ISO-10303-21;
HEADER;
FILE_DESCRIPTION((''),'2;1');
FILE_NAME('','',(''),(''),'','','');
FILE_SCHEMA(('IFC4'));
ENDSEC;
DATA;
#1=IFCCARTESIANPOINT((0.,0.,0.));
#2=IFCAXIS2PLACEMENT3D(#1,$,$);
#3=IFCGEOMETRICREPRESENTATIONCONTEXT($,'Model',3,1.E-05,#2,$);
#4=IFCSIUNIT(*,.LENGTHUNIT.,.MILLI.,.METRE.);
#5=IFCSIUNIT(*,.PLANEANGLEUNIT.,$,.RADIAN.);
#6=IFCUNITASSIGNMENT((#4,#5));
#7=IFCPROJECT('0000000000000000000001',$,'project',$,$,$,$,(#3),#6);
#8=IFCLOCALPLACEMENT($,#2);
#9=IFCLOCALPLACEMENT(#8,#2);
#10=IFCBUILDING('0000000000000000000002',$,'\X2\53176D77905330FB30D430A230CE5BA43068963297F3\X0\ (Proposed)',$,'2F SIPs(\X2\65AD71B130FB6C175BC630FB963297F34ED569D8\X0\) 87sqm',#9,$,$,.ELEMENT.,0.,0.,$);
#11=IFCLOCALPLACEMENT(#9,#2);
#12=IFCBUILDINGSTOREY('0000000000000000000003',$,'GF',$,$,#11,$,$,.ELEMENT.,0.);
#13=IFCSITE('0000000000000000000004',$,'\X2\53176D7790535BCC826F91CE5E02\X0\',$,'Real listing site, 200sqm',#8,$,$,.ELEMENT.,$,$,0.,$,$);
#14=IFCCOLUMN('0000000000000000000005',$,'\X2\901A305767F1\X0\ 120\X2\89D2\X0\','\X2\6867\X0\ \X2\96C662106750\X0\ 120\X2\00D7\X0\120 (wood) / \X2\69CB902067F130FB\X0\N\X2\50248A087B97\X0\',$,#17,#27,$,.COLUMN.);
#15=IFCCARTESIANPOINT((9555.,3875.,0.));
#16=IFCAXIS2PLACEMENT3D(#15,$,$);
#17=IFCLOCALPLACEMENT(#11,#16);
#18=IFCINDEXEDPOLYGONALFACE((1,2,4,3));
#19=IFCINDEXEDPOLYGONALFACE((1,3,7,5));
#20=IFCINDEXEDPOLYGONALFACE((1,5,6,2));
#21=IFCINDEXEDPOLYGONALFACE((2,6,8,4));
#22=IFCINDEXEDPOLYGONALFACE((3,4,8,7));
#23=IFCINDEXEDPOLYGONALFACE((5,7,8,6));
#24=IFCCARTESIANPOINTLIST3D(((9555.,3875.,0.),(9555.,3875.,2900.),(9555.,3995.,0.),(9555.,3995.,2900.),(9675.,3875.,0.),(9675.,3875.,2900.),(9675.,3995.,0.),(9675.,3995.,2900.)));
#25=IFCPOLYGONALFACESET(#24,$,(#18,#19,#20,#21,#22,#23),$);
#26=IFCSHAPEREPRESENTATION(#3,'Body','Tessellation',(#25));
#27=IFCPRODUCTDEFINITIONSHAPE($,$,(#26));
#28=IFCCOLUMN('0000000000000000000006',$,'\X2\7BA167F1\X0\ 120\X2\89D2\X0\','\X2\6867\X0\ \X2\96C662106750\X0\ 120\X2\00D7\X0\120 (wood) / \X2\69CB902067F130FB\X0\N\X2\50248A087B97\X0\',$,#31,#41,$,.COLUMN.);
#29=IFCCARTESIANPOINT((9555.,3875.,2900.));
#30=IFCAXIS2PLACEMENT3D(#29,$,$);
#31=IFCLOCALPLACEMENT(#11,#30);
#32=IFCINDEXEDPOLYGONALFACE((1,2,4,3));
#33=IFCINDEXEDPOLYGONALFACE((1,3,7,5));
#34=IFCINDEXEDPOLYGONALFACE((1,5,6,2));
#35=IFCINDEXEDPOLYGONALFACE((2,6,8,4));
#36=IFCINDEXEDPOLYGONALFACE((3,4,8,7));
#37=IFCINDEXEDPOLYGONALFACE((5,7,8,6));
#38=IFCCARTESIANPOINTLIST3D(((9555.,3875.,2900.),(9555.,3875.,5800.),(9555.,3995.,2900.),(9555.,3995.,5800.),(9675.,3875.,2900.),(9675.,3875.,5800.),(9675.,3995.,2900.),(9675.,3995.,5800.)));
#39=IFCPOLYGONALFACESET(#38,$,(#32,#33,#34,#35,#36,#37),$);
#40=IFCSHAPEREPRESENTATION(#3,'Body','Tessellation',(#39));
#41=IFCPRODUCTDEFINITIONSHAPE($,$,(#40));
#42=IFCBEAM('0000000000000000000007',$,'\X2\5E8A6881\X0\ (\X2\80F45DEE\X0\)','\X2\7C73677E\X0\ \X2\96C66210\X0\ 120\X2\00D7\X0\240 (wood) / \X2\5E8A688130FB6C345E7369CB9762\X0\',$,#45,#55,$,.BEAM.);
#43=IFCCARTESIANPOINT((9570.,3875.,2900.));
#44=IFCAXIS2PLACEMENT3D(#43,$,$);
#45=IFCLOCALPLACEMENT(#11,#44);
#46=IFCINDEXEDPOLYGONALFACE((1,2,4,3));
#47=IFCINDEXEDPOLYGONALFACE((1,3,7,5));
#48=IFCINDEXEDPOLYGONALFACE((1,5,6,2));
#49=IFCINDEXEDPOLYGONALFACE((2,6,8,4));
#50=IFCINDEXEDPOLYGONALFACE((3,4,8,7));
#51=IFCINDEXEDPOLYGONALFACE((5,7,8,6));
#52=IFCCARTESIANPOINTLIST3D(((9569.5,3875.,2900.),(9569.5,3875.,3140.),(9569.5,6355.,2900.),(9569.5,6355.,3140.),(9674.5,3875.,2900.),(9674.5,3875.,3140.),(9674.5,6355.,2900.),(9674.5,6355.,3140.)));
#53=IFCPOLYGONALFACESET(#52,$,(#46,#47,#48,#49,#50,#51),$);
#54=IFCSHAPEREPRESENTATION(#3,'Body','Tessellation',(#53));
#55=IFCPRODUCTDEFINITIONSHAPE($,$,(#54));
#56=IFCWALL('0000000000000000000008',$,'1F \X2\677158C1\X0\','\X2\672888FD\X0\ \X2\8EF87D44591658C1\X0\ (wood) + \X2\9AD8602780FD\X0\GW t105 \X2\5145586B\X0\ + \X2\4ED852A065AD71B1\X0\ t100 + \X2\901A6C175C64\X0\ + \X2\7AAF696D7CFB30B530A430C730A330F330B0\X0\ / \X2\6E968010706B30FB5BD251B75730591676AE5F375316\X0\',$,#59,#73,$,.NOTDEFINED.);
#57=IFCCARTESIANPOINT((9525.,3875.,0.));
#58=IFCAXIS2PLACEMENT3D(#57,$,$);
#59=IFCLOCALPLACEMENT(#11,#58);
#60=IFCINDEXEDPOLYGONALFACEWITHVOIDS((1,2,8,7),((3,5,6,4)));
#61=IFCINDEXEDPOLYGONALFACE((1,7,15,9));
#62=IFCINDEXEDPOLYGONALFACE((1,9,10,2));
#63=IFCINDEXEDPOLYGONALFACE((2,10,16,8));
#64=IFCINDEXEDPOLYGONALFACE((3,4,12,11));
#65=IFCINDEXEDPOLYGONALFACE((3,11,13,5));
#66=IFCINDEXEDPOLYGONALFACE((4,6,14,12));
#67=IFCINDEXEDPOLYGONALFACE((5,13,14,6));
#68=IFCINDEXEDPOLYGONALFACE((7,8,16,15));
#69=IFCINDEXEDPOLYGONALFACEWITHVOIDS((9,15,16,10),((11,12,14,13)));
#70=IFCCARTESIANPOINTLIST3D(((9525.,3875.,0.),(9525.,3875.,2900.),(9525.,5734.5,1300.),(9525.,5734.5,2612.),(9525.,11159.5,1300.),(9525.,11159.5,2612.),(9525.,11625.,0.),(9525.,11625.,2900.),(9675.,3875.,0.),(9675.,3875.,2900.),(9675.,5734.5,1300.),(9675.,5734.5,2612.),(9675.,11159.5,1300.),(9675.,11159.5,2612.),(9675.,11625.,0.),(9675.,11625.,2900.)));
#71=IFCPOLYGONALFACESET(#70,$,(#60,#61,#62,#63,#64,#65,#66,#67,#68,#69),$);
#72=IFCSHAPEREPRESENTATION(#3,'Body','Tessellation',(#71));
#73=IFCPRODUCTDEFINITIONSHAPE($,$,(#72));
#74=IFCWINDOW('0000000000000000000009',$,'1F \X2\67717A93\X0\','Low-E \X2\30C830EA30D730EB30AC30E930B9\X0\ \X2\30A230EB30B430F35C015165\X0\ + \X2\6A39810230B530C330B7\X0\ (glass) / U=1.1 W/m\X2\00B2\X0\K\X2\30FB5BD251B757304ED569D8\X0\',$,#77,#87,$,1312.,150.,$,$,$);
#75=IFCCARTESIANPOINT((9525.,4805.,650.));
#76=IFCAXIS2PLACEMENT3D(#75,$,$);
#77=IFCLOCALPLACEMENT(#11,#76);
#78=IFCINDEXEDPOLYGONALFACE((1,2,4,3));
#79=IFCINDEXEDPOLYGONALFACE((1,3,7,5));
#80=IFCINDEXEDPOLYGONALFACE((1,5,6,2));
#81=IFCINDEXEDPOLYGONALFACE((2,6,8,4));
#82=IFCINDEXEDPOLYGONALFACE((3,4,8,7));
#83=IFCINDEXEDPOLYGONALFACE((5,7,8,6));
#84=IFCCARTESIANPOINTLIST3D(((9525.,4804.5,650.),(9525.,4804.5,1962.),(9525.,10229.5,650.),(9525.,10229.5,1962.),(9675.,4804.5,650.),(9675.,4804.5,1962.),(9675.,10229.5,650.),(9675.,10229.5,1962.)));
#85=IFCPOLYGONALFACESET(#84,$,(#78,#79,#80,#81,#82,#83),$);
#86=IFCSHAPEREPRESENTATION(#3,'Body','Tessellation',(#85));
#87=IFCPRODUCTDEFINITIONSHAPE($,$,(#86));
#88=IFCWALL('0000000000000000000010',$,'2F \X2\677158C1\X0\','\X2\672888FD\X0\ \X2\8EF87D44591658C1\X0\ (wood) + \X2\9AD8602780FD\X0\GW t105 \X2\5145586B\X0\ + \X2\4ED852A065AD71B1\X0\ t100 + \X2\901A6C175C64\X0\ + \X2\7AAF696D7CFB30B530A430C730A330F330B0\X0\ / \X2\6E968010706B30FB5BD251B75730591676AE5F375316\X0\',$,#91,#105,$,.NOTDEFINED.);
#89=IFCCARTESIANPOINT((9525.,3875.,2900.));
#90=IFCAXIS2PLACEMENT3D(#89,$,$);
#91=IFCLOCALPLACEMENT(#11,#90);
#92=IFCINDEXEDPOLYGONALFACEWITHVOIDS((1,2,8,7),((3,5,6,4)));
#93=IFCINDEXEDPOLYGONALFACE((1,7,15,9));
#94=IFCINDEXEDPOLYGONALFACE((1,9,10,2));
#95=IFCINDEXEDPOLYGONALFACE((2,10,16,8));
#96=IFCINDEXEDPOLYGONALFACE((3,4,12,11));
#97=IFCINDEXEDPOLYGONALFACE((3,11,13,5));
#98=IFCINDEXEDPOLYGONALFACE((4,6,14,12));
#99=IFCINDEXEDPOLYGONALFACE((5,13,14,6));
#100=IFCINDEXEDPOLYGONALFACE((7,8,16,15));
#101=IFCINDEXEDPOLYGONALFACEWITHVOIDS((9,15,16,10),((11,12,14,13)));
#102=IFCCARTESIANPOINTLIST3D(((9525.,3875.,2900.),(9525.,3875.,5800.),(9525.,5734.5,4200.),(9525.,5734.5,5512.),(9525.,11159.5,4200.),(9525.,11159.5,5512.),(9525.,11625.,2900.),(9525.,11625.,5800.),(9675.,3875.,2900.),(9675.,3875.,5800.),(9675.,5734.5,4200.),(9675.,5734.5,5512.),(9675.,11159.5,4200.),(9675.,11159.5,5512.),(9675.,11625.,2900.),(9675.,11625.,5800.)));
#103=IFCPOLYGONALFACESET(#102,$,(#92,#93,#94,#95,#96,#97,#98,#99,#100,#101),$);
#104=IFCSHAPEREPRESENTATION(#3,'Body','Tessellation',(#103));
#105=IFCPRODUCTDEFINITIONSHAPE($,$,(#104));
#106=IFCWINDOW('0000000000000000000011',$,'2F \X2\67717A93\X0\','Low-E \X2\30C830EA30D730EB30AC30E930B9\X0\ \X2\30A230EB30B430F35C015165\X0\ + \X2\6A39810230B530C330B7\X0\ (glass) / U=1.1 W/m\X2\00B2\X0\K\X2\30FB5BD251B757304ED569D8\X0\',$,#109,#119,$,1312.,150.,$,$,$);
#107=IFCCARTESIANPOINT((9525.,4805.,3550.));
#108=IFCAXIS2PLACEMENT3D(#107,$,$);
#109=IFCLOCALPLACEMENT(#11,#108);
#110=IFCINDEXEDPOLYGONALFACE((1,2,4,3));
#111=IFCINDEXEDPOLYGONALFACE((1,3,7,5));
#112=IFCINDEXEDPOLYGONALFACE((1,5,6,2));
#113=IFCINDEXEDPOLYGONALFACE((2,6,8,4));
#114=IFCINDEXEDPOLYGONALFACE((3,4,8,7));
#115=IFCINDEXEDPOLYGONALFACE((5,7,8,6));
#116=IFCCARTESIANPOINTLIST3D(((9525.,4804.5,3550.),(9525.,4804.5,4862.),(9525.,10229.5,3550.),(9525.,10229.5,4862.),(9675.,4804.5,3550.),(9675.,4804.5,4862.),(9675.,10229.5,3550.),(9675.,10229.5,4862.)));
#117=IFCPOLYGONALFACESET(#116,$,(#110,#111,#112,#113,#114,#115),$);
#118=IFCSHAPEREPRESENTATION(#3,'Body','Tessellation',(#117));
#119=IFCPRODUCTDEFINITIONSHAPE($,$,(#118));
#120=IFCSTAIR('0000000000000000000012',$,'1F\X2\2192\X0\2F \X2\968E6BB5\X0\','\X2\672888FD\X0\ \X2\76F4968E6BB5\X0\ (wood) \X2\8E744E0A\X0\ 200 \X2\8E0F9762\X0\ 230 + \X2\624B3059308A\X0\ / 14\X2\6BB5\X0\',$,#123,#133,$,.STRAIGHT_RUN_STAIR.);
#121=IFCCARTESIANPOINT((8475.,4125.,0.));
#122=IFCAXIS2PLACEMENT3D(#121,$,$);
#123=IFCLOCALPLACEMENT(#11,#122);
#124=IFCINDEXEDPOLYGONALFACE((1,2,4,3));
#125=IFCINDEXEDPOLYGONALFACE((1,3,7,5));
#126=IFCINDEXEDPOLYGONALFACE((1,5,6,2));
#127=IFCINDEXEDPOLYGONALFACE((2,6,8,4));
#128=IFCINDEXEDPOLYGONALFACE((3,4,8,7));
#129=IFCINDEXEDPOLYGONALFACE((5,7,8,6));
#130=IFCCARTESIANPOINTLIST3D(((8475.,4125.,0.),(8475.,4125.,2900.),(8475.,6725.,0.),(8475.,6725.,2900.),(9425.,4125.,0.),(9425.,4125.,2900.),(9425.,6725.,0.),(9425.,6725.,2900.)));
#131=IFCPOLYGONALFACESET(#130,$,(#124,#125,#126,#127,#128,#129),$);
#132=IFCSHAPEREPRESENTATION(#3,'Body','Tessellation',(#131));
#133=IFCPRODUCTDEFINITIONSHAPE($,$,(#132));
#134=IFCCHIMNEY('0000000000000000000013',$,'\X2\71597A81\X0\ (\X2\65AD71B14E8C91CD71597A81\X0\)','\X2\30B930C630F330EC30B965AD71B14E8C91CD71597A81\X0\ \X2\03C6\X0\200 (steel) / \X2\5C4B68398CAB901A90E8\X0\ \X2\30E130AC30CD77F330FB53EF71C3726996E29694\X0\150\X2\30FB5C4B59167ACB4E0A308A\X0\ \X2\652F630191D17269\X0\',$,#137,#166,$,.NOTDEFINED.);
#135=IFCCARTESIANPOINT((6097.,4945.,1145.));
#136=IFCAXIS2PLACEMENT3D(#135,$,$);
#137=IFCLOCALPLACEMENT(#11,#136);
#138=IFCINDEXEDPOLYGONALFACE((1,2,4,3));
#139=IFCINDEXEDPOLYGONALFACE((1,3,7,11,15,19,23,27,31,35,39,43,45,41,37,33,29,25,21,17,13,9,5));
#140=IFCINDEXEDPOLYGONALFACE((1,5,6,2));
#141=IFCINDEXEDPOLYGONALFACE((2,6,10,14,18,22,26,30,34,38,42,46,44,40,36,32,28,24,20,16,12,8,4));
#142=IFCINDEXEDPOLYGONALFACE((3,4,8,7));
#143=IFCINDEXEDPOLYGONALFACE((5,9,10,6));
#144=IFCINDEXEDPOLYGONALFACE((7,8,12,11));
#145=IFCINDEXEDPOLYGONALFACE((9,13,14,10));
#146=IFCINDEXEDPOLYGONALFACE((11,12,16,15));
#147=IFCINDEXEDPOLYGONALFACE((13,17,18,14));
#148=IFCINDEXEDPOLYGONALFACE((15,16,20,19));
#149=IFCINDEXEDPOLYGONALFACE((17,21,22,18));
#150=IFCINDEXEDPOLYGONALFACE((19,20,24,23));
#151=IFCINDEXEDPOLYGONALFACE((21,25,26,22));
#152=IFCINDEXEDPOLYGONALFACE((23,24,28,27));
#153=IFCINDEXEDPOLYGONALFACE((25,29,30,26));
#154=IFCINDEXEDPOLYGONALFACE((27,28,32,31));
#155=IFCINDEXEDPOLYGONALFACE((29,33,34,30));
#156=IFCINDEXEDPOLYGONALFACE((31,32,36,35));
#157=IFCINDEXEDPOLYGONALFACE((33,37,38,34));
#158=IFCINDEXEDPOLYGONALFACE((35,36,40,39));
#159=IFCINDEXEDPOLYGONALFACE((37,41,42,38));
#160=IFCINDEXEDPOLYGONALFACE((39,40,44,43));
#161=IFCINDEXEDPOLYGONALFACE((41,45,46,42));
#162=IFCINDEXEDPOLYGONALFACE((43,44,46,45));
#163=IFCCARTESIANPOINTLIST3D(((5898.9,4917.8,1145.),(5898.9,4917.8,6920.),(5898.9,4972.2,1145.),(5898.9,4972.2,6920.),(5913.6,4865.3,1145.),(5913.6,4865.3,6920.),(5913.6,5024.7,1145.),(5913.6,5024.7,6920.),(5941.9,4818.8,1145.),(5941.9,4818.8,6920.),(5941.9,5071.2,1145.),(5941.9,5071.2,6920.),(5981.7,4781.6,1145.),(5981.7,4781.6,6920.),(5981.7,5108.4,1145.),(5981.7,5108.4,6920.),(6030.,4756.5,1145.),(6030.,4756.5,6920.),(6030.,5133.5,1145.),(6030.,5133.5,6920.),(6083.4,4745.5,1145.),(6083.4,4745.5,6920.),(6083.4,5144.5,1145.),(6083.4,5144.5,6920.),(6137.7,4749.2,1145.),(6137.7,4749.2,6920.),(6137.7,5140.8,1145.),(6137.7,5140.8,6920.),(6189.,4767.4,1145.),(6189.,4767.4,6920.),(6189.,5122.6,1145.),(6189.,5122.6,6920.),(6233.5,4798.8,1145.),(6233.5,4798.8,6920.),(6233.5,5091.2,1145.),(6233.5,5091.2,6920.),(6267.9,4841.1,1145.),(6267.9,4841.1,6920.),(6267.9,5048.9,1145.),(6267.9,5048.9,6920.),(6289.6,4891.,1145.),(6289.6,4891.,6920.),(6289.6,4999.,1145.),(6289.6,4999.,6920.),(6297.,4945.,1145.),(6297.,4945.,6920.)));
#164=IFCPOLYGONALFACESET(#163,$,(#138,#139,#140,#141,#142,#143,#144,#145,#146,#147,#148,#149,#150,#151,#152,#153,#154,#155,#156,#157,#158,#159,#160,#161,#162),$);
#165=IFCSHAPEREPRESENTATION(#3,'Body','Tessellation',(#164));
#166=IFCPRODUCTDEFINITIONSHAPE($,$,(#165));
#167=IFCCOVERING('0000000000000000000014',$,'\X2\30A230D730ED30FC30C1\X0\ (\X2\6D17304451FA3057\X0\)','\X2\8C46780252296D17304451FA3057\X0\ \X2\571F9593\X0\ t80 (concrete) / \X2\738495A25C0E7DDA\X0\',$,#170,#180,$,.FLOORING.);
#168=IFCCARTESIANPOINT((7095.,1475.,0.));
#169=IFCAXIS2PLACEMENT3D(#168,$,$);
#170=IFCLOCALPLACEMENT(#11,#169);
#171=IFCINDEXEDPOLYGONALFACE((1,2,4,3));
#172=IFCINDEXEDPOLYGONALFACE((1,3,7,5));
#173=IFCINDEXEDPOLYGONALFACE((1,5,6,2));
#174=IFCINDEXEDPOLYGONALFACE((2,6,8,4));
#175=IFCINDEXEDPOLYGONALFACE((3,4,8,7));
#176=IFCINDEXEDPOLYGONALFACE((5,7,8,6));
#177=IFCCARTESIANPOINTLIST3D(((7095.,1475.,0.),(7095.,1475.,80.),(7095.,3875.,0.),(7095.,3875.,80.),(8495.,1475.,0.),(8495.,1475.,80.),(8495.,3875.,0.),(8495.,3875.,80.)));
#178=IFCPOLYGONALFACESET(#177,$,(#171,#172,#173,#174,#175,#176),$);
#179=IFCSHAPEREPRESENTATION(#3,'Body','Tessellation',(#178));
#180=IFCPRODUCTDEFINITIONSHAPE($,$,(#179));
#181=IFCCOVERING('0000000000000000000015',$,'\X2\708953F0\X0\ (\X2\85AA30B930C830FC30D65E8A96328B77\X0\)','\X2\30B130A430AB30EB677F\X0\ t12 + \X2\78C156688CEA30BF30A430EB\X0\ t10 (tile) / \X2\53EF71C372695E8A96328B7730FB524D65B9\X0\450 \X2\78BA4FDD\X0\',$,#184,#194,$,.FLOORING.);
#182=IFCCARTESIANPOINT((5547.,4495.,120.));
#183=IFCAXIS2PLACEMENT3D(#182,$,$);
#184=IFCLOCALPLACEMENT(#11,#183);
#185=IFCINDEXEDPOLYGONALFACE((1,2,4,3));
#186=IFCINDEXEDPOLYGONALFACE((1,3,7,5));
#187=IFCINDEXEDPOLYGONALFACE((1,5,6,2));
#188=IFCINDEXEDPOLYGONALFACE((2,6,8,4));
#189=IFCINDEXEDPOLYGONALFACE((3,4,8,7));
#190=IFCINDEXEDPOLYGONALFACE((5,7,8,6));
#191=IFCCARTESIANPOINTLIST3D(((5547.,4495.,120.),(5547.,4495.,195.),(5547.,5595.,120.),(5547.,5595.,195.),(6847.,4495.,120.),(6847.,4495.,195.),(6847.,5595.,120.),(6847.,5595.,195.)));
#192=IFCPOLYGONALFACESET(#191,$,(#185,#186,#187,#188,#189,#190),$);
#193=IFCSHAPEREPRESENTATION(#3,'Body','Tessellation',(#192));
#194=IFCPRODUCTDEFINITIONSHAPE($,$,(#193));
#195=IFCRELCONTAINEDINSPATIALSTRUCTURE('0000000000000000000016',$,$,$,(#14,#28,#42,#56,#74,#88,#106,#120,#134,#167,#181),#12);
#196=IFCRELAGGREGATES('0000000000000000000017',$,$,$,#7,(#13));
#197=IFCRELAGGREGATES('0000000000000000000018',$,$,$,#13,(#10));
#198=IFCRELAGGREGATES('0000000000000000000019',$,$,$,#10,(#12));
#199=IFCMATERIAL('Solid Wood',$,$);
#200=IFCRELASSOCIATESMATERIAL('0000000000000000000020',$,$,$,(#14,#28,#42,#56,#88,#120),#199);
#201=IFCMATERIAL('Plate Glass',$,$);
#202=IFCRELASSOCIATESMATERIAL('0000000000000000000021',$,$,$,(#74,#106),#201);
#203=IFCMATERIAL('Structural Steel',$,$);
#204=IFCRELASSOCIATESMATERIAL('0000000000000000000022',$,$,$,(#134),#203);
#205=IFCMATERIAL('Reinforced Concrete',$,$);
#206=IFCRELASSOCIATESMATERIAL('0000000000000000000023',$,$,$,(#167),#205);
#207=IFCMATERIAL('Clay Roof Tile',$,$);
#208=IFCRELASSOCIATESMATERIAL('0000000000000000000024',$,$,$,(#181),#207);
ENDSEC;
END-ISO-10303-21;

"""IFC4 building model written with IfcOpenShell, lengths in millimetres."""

from ifc_helpers import new_model, si_unit, frame, frame_2d, origin, origin_2d, place, context, project, spatial, rectangle, circle, extrude, material, element, fill, save


model = new_model("IFC4")

# Units and contexts
model_context = context("Model", 3, precision=1e-05, world=origin())
ifc_project = project(units=[si_unit("LENGTHUNIT", "METRE", prefix="MILLI"), si_unit("PLANEANGLEUNIT", "RADIAN")], contexts=[model_context])

# Site, building, storey
site_placement = place(None, origin())
site = spatial("IfcSite", under=ifc_project, at=site_placement, Name="北海道富良野市", ObjectType="Real listing site, 200sqm", CompositionType="ELEMENT", RefElevation=0.0)
building_placement = place(site_placement, origin())
building = spatial("IfcBuilding", under=site, at=building_placement, Name="北海道・ピアノ室と防音 (Proposed)", ObjectType="2F SIPs(断熱・気密・防音仕様) 87sqm", CompositionType="ELEMENT", ElevationOfRefHeight=0.0, ElevationOfTerrain=0.0)
storey_placement = place(building_placement, origin())
storey = spatial("IfcBuildingStorey", under=building, at=storey_placement, Name="GF", CompositionType="ELEMENT", Elevation=0.0)

# Columns
ifc_material_1 = material(Name="Solid Wood")
column_1_placement = place(storey_placement, frame((9555.0, 3875.0, 0.0)))
element("IfcColumn", 1, at=column_1_placement, inside=storey, material=ifc_material_1, Name="通し柱 120角", Description="桧 集成材 120×120 (wood) / 構造柱・N値計算", PredefinedType="COLUMN", context=model_context, shape_type="SweptSolid", body=[
    extrude(rectangle(XDim=120.0, YDim=120.0, at=frame_2d((60.0, 60.0))), frame((9555.0, 3875.0, 0.0)), (0.0, 0.0, 1.0), 2900.0),
])
column_2_placement = place(storey_placement, frame((9555.0, 3875.0, 2900.0)))
element("IfcColumn", 2, at=column_2_placement, inside=storey, material=ifc_material_1, Name="管柱 120角", Description="桧 集成材 120×120 (wood) / 構造柱・N値計算", PredefinedType="COLUMN", context=model_context, shape_type="SweptSolid", body=[
    extrude(rectangle(XDim=120.0, YDim=120.0, at=frame_2d((60.0, 60.0))), frame((9555.0, 3875.0, 2900.0)), (0.0, 0.0, 1.0), 2900.0),
])

# Beam
beam_1_placement = place(storey_placement, frame((9570.0, 3875.0, 2900.0)))
element("IfcBeam", 3, at=beam_1_placement, inside=storey, material=ifc_material_1, Name="床梁 (胴差)", Description="米松 集成 120×240 (wood) / 床梁・水平構面", PredefinedType="BEAM", context=model_context, shape_type="SweptSolid", body=[
    extrude(rectangle(XDim=105.0, YDim=2480.0, at=frame_2d((52.0, 1240.0))), frame((9570.0, 3875.0, 2900.0)), (0.0, 0.0, 1.0), 240.0),
])

# Wall, opening, window
wall_1_placement = place(storey_placement, frame((9525.0, 3875.0, 0.0)))
wall_1 = element("IfcWall", 4, at=wall_1_placement, inside=storey, material=ifc_material_1, Name="1F 東壁", Description="木製 軸組外壁 (wood) + 高性能GW t105 充填 + 付加断熱 t100 + 通気層 + 窯業系サイディング / 準耐火・寒冷地外皮強化", PredefinedType="NOTDEFINED", context=model_context, shape_type="SweptSolid", body=[
    extrude(rectangle(XDim=150.0, YDim=7750.0, at=frame_2d((75.0, 3875.0))), frame((9525.0, 3875.0, 0.0)), (0.0, 0.0, 1.0), 2900.0),
])
opening_1_placement = place(storey_placement, frame((9525.0, 4805.0, 650.0)))
opening_1 = element("IfcOpeningElement", 5, at=opening_1_placement, cuts=wall_1, PredefinedType="NOTDEFINED", context=model_context, shape_type="SweptSolid", body=[
    extrude(rectangle(XDim=150.0, YDim=5425.0, at=frame_2d((75.0, 2712.0))), frame((9525.0, 4805.0, 650.0)), (0.0, 0.0, 1.0), 1312.0),
])
ifc_material_2 = material(Name="Plate Glass")
window_1_placement = place(storey_placement, frame((9525.0, 4805.0, 650.0)))
window_1 = element("IfcWindow", 6, at=window_1_placement, inside=storey, material=ifc_material_2, Name="1F 東窓", Description="Low-E トリプルガラス アルゴン封入 + 樹脂サッシ (glass) / U=1.1 W/m²K・寒冷地仕様", OverallHeight=1312.0, OverallWidth=150.0, context=model_context, shape_type="SweptSolid", body=[
    extrude(rectangle(XDim=150.0, YDim=5425.0, at=frame_2d((75.0, 2712.0))), frame((9525.0, 4805.0, 650.0)), (0.0, 0.0, 1.0), 1312.0),
])
fill(opening_1, window_1)

# Wall, opening, window
wall_2_placement = place(storey_placement, frame((9525.0, 3875.0, 2900.0)))
wall_2 = element("IfcWall", 7, at=wall_2_placement, inside=storey, material=ifc_material_1, Name="2F 東壁", Description="木製 軸組外壁 (wood) + 高性能GW t105 充填 + 付加断熱 t100 + 通気層 + 窯業系サイディング / 準耐火・寒冷地外皮強化", PredefinedType="NOTDEFINED", context=model_context, shape_type="SweptSolid", body=[
    extrude(rectangle(XDim=150.0, YDim=7750.0, at=frame_2d((75.0, 3875.0))), frame((9525.0, 3875.0, 2900.0)), (0.0, 0.0, 1.0), 2900.0),
])
opening_2_placement = place(storey_placement, frame((9525.0, 4805.0, 3550.0)))
opening_2 = element("IfcOpeningElement", 8, at=opening_2_placement, cuts=wall_2, PredefinedType="NOTDEFINED", context=model_context, shape_type="SweptSolid", body=[
    extrude(rectangle(XDim=150.0, YDim=5425.0, at=frame_2d((75.0, 2712.0))), frame((9525.0, 4805.0, 3550.0)), (0.0, 0.0, 1.0), 1312.0),
])
window_2_placement = place(storey_placement, frame((9525.0, 4805.0, 3550.0)))
window_2 = element("IfcWindow", 9, at=window_2_placement, inside=storey, material=ifc_material_2, Name="2F 東窓", Description="Low-E トリプルガラス アルゴン封入 + 樹脂サッシ (glass) / U=1.1 W/m²K・寒冷地仕様", OverallHeight=1312.0, OverallWidth=150.0, context=model_context, shape_type="SweptSolid", body=[
    extrude(rectangle(XDim=150.0, YDim=5425.0, at=frame_2d((75.0, 2712.0))), frame((9525.0, 4805.0, 3550.0)), (0.0, 0.0, 1.0), 1312.0),
])
fill(opening_2, window_2)

# Stair
stair_placement = place(storey_placement, frame((8475.0, 4125.0, 0.0)))
element("IfcStair", 10, at=stair_placement, inside=storey, material=ifc_material_1, Name="1F→2F 階段", Description="木製 直階段 (wood) 蹴上 200 踏面 230 + 手すり / 14段", PredefinedType="STRAIGHT_RUN_STAIR", context=model_context, shape_type="SweptSolid", body=[
    extrude(rectangle(XDim=950.0, YDim=2600.0, at=frame_2d((475.0, 1300.0))), frame((8475.0, 4125.0, 0.0)), (0.0, 0.0, 1.0), 2900.0),
])

# Chimney
ifc_material_3 = material(Name="Structural Steel")
chimney_placement = place(storey_placement, frame((6097.0, 4945.0, 1145.0)))
element("IfcChimney", 11, at=chimney_placement, inside=storey, material=ifc_material_3, Name="煙突 (断熱二重煙突)", Description="ステンレス断熱二重煙突 φ200 (steel) / 屋根貫通部 メガネ石・可燃物離隔150・屋外立上り 支持金物", PredefinedType="NOTDEFINED", context=model_context, shape_type="SweptSolid", body=[
    extrude(circle(Radius=200.0, at=origin_2d()), frame((6097.0, 4945.0, 1145.0)), (0.0, 0.0, 1.0), 5775.0),
])

# Coverings
ifc_material_4 = material(Name="Reinforced Concrete")
covering_1_placement = place(storey_placement, frame((7095.0, 1475.0, 0.0)))
element("IfcCovering", 12, at=covering_1_placement, inside=storey, material=ifc_material_4, Name="アプローチ (洗い出し)", Description="豆砂利洗い出し 土間 t80 (concrete) / 玄関導線", PredefinedType="FLOORING", context=model_context, shape_type="SweptSolid", body=[
    extrude(rectangle(XDim=1400.0, YDim=2400.0, at=frame_2d((700.0, 1200.0))), frame((7095.0, 1475.0, 0.0)), (0.0, 0.0, 1.0), 80.0),
])
ifc_material_5 = material(Name="Clay Roof Tile")
covering_2_placement = place(storey_placement, frame((5547.0, 4495.0, 120.0)))
element("IfcCovering", 13, at=covering_2_placement, inside=storey, material=ifc_material_5, Name="炉台 (薪ストーブ床防護)", Description="ケイカル板 t12 + 磁器質タイル t10 (tile) / 可燃物床防護・前方450 確保", PredefinedType="FLOORING", context=model_context, shape_type="SweptSolid", body=[
    extrude(rectangle(XDim=1300.0, YDim=1100.0, at=frame_2d((650.0, 550.0))), frame((5547.0, 4495.0, 120.0)), (0.0, 0.0, 1.0), 75.0),
])

save(model, "model.ifc")
